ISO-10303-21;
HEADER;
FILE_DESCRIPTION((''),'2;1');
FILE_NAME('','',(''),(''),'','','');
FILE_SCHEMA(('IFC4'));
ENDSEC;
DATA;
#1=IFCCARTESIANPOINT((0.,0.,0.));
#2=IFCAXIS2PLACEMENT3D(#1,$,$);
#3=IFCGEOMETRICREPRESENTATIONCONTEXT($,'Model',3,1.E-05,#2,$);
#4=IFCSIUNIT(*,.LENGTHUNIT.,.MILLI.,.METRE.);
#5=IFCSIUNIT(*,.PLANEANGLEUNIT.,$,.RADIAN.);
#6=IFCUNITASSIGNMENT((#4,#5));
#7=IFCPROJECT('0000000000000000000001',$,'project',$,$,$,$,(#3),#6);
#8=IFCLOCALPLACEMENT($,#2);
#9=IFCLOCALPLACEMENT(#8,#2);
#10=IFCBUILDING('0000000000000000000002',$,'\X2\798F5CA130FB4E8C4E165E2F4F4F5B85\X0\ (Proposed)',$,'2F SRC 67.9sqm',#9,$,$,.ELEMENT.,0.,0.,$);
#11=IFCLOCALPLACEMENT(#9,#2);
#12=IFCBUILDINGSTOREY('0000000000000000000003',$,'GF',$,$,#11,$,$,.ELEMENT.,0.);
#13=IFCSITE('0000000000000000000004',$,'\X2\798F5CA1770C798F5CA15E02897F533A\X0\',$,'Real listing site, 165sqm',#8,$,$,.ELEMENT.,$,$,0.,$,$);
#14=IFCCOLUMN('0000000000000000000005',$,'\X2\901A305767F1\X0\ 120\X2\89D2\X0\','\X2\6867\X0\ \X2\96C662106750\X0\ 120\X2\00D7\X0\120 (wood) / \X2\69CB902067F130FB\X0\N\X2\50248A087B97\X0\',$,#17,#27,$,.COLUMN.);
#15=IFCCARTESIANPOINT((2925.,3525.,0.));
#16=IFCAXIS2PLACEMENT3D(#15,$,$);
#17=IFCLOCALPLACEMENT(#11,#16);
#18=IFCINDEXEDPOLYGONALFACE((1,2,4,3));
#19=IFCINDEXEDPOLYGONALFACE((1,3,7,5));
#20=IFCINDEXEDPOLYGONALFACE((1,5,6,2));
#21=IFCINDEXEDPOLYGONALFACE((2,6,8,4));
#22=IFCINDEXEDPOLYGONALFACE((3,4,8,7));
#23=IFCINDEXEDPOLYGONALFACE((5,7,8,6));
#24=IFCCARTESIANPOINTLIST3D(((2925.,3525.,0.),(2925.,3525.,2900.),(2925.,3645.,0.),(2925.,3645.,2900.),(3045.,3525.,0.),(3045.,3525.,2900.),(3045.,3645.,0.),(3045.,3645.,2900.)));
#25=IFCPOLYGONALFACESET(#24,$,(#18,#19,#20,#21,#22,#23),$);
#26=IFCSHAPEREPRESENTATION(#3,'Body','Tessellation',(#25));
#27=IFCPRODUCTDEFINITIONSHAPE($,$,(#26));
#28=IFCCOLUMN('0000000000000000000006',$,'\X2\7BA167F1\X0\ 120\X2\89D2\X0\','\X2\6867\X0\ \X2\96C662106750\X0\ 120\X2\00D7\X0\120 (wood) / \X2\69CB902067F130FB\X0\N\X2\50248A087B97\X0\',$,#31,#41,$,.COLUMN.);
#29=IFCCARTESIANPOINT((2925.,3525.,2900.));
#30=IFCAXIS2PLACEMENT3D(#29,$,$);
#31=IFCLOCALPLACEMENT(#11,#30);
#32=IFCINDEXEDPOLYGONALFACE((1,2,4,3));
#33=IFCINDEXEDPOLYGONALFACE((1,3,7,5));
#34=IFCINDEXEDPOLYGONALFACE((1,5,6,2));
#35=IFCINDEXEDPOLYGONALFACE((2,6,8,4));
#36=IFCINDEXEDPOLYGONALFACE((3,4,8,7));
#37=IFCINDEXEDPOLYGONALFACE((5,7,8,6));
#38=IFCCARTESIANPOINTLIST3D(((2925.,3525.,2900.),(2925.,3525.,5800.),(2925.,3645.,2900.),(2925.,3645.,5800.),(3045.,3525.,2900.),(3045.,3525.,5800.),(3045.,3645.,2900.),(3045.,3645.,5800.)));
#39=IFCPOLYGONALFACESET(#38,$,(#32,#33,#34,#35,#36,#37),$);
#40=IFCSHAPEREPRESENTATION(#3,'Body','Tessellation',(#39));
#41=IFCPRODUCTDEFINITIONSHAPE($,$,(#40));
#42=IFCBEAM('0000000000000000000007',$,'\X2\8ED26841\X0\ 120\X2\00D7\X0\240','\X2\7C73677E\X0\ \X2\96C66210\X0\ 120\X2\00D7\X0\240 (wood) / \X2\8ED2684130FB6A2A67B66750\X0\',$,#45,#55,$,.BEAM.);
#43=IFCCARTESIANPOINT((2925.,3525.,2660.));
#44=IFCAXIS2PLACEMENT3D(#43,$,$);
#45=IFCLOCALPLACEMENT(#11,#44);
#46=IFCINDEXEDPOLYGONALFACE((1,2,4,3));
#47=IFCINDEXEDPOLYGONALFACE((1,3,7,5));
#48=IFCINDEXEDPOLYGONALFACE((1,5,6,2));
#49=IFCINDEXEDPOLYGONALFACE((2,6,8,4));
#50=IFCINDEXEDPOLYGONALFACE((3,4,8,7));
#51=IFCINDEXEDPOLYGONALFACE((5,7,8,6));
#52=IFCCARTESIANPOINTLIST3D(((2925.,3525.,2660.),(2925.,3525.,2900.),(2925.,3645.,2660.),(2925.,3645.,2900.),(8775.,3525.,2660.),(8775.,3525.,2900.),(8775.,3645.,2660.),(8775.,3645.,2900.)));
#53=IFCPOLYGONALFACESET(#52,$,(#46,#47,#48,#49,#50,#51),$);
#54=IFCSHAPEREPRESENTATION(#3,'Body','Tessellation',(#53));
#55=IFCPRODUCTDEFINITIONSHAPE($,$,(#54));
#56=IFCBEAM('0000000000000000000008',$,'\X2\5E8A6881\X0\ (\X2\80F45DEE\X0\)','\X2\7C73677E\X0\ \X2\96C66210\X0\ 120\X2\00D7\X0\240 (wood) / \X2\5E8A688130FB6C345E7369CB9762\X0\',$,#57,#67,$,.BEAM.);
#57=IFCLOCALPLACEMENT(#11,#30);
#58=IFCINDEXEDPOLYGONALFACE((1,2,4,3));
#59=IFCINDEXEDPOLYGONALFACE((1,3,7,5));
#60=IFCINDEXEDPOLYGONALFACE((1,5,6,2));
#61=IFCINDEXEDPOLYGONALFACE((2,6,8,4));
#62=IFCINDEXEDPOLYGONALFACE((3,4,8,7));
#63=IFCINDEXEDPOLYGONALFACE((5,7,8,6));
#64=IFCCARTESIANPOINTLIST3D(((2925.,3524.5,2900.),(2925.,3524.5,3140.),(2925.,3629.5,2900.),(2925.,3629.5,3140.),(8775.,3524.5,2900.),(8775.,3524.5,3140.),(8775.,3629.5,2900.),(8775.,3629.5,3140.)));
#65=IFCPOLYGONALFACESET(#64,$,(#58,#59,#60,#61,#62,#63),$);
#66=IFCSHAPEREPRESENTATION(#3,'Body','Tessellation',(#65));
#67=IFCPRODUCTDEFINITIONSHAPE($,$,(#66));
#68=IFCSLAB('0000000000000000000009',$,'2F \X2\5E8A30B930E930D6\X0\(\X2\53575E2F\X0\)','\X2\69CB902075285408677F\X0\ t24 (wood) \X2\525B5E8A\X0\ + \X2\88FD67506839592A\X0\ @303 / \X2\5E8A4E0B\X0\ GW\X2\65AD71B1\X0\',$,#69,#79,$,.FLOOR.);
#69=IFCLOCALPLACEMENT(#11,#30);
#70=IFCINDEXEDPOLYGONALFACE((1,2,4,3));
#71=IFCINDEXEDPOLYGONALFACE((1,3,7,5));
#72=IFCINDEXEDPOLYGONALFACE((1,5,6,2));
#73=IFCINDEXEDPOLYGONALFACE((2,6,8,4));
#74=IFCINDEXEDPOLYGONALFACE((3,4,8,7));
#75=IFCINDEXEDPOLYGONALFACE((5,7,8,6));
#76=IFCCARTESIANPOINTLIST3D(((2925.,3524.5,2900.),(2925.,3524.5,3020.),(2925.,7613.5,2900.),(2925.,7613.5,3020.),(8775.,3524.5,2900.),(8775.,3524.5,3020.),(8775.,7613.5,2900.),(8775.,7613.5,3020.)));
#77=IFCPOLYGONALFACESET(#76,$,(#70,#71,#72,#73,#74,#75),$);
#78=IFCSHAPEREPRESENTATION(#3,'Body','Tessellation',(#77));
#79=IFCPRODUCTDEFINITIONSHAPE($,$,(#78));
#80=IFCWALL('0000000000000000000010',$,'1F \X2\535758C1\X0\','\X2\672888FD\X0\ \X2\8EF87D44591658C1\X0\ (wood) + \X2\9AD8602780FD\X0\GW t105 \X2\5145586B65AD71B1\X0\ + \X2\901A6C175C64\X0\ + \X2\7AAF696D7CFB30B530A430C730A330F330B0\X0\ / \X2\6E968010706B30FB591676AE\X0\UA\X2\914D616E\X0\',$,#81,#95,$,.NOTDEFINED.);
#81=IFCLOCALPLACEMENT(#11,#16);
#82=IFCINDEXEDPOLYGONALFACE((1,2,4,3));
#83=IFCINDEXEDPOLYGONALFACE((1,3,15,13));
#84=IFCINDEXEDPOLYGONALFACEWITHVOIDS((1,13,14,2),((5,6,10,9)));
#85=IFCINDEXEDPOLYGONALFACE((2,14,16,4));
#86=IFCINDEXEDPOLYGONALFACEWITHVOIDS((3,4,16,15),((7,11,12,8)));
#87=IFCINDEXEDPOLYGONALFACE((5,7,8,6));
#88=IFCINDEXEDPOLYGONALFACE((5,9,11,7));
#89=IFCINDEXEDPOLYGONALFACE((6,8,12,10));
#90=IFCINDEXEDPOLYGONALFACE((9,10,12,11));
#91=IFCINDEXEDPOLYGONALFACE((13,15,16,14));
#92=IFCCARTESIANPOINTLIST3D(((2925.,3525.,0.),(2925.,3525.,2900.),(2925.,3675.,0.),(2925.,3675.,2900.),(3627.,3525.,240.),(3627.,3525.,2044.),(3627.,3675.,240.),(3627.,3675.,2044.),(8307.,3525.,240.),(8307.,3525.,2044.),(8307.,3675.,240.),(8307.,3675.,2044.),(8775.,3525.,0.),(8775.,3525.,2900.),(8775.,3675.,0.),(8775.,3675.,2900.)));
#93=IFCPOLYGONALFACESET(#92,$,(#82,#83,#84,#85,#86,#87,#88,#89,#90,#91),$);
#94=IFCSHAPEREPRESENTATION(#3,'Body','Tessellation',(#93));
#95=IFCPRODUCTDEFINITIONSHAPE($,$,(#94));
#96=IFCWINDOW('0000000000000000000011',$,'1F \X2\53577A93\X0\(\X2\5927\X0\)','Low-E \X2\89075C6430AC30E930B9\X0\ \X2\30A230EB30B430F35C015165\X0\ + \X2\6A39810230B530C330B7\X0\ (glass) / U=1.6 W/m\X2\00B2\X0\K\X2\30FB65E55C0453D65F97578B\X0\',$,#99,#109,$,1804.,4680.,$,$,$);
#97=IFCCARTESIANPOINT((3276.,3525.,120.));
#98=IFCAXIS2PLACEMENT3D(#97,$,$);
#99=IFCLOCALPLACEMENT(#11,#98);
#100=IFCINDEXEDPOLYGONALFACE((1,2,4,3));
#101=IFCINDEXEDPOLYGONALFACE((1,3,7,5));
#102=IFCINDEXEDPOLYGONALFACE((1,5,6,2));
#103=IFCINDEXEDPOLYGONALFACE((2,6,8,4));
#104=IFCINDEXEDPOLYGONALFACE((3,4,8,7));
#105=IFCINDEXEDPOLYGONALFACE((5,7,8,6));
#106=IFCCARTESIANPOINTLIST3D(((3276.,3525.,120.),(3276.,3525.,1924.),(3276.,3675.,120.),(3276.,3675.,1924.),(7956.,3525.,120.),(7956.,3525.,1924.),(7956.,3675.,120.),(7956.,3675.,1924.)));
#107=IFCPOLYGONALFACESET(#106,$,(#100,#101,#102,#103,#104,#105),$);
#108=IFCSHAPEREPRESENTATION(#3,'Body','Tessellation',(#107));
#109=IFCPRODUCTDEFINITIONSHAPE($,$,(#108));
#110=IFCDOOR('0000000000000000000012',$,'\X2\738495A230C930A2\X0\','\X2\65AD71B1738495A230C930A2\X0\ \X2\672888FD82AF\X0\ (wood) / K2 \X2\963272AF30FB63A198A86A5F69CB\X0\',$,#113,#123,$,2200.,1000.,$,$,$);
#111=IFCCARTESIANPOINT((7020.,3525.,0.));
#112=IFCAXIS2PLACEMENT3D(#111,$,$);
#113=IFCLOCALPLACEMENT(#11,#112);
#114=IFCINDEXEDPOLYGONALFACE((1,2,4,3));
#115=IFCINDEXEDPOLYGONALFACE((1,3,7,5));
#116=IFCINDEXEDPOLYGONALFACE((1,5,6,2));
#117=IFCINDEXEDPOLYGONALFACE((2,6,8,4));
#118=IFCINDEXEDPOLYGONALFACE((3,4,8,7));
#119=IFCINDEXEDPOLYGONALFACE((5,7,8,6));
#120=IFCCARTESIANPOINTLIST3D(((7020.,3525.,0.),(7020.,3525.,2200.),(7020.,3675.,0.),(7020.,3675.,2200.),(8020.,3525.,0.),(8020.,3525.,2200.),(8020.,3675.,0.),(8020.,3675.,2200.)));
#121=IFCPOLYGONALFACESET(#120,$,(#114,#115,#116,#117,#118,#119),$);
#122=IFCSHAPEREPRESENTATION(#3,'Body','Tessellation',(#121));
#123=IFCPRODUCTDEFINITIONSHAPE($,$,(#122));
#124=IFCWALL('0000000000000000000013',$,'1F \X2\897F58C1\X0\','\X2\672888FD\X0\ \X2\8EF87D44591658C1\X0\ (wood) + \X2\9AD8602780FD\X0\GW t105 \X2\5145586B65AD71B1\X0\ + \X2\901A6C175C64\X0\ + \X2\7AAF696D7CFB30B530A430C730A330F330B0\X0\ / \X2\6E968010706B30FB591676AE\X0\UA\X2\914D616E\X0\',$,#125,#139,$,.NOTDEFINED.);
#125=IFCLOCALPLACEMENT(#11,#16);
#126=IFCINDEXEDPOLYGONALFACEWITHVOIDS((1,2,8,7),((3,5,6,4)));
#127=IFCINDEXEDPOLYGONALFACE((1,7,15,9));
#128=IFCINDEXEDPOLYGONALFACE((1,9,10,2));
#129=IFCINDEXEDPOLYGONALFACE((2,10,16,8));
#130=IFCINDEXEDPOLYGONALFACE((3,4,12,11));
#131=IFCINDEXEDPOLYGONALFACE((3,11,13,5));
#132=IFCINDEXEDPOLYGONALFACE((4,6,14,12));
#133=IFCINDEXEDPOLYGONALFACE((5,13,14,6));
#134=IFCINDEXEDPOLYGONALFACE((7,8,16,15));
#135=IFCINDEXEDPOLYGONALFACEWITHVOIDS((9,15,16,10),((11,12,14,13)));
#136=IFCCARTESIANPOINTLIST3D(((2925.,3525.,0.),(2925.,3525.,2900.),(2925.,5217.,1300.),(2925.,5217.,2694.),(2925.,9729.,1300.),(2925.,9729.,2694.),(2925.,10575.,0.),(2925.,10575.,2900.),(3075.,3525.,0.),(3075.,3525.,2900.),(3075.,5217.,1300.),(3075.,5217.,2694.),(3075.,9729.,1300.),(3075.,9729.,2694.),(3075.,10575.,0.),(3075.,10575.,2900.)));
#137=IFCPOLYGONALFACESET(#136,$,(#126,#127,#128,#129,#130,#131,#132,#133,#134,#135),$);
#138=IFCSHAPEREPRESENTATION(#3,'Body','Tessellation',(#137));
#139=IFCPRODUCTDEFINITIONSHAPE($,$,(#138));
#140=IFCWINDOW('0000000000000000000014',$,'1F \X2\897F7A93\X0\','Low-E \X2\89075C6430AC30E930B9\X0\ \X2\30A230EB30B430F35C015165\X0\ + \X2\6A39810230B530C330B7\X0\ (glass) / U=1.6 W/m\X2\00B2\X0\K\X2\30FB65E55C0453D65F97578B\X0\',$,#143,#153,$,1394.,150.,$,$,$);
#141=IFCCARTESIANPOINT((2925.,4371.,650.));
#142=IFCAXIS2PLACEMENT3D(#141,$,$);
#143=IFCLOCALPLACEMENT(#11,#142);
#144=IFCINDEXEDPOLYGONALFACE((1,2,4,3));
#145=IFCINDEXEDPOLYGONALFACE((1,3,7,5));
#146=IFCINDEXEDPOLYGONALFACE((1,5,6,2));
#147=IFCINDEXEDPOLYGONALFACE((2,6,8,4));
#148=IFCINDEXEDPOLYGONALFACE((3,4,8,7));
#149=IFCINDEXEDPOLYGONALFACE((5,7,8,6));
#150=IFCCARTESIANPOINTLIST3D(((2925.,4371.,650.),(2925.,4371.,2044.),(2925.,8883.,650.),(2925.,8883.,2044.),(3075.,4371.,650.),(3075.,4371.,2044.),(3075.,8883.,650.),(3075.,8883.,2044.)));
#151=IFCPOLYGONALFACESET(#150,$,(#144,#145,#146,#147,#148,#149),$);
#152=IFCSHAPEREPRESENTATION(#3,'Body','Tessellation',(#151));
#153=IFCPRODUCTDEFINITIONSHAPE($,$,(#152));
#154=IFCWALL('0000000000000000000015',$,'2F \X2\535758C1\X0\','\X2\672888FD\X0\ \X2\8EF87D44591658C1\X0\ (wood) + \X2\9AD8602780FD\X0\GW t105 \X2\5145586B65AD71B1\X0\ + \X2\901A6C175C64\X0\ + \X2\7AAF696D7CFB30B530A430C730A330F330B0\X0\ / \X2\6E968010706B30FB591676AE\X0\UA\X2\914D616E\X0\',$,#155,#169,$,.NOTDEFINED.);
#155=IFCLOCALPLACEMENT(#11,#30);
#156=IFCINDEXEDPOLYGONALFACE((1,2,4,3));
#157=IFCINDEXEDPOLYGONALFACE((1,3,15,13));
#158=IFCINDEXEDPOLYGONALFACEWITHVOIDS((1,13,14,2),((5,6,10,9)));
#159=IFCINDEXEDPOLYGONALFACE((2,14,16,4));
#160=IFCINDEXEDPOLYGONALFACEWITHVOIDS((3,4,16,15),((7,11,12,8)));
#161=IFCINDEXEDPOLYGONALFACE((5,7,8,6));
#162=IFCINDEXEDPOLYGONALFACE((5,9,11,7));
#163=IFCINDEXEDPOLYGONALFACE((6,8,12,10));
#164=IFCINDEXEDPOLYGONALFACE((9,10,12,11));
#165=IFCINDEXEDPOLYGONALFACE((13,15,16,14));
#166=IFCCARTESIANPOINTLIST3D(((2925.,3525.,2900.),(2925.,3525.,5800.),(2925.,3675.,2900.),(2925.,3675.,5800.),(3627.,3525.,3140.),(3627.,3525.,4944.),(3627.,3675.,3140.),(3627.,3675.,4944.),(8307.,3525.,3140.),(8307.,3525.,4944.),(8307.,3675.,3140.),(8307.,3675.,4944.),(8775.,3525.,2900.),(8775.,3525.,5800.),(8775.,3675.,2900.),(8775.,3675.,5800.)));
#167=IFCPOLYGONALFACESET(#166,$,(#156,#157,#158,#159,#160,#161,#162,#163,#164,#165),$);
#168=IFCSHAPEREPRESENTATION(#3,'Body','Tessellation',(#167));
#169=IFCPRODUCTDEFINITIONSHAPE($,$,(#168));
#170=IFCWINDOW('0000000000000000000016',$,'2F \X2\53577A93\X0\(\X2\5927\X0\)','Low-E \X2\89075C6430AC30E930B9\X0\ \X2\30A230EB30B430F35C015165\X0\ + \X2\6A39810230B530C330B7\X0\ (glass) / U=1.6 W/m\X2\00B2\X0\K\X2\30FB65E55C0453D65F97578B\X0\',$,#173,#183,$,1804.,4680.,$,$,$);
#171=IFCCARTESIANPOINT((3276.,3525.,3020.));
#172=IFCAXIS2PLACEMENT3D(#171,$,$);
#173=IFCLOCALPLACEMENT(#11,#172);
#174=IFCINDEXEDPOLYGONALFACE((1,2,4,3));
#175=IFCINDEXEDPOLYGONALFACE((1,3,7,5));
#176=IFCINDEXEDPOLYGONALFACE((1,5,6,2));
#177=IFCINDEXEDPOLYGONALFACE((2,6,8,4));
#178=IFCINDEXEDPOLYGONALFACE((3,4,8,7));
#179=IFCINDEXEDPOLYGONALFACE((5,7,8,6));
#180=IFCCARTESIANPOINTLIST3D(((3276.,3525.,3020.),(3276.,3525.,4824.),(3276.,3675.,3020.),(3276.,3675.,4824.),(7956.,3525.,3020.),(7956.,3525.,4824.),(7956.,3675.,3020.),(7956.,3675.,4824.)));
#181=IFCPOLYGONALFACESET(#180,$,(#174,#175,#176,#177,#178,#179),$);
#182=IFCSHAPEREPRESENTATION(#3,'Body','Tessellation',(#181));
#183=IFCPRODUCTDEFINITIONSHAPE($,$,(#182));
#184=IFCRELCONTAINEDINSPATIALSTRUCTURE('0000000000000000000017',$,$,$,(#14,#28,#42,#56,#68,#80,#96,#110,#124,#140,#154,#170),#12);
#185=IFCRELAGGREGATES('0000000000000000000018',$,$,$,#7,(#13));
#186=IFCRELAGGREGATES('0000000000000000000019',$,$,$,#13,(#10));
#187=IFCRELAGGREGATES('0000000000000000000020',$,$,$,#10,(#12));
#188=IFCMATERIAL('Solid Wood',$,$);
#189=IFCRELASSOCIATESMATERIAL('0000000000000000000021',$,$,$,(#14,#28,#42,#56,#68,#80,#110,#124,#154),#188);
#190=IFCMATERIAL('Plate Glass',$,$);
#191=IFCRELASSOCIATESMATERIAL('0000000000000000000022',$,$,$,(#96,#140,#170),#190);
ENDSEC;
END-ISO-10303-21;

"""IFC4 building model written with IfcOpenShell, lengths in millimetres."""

from ifc_helpers import new_model, si_unit, frame, frame_2d, origin, place, context, project, spatial, rectangle, extrude, material, element, fill, save


model = new_model("IFC4")

# Units and contexts
model_context = context("Model", 3, precision=1e-05, world=origin())
ifc_project = project(units=[si_unit("LENGTHUNIT", "METRE", prefix="MILLI"), si_unit("PLANEANGLEUNIT", "RADIAN")], contexts=[model_context])

# Site, building, storey
site_placement = place(None, origin())
site = spatial("IfcSite", under=ifc_project, at=site_placement, Name="福岡県福岡市西区", ObjectType="Real listing site, 165sqm", CompositionType="ELEMENT", RefElevation=0.0)
building_placement = place(site_placement, origin())
building = spatial("IfcBuilding", under=site, at=building_placement, Name="福岡・二世帯住宅 (Proposed)", ObjectType="2F SRC 67.9sqm", CompositionType="ELEMENT", ElevationOfRefHeight=0.0, ElevationOfTerrain=0.0)
storey_placement = place(building_placement, origin())
storey = spatial("IfcBuildingStorey", under=building, at=storey_placement, Name="GF", CompositionType="ELEMENT", Elevation=0.0)

# Columns
ifc_material_1 = material(Name="Solid Wood")
column_1_placement = place(storey_placement, frame((2925.0, 3525.0, 0.0)))
element("IfcColumn", 1, at=column_1_placement, inside=storey, material=ifc_material_1, Name="通し柱 120角", Description="桧 集成材 120×120 (wood) / 構造柱・N値計算", PredefinedType="COLUMN", context=model_context, shape_type="SweptSolid", body=[
    extrude(rectangle(XDim=120.0, YDim=120.0, at=frame_2d((60.0, 60.0))), frame((2925.0, 3525.0, 0.0)), (0.0, 0.0, 1.0), 2900.0),
])
column_2_placement = place(storey_placement, frame((2925.0, 3525.0, 2900.0)))
element("IfcColumn", 2, at=column_2_placement, inside=storey, material=ifc_material_1, Name="管柱 120角", Description="桧 集成材 120×120 (wood) / 構造柱・N値計算", PredefinedType="COLUMN", context=model_context, shape_type="SweptSolid", body=[
    extrude(rectangle(XDim=120.0, YDim=120.0, at=frame_2d((60.0, 60.0))), frame((2925.0, 3525.0, 2900.0)), (0.0, 0.0, 1.0), 2900.0),
])

# Beams
beam_1_placement = place(storey_placement, frame((2925.0, 3525.0, 2660.0)))
element("IfcBeam", 3, at=beam_1_placement, inside=storey, material=ifc_material_1, Name="軒桁 120×240", Description="米松 集成 120×240 (wood) / 軒桁・横架材", PredefinedType="BEAM", context=model_context, shape_type="SweptSolid", body=[
    extrude(rectangle(XDim=5850.0, YDim=120.0, at=frame_2d((2925.0, 60.0))), frame((2925.0, 3525.0, 2660.0)), (0.0, 0.0, 1.0), 240.0),
])
beam_2_placement = place(storey_placement, frame((2925.0, 3525.0, 2900.0)))
element("IfcBeam", 4, at=beam_2_placement, inside=storey, material=ifc_material_1, Name="床梁 (胴差)", Description="米松 集成 120×240 (wood) / 床梁・水平構面", PredefinedType="BEAM", context=model_context, shape_type="SweptSolid", body=[
    extrude(rectangle(XDim=5850.0, YDim=105.0, at=frame_2d((2925.0, 52.0))), frame((2925.0, 3525.0, 2900.0)), (0.0, 0.0, 1.0), 240.0),
])

# Slab
slab_1_placement = place(storey_placement, frame((2925.0, 3525.0, 2900.0)))
element("IfcSlab", 5, at=slab_1_placement, inside=storey, material=ifc_material_1, Name="2F 床スラブ(南帯)", Description="構造用合板 t24 (wood) 剛床 + 製材根太 @303 / 床下 GW断熱", PredefinedType="FLOOR", context=model_context, shape_type="SweptSolid", body=[
    extrude(rectangle(XDim=5850.0, YDim=4089.0, at=frame_2d((2925.0, 2044.0))), frame((2925.0, 3525.0, 2900.0)), (0.0, 0.0, 1.0), 120.0),
])

# Wall, openings, window, door
wall_1_placement = place(storey_placement, frame((2925.0, 3525.0, 0.0)))
wall_1 = element("IfcWall", 6, at=wall_1_placement, inside=storey, material=ifc_material_1, Name="1F 南壁", Description="木製 軸組外壁 (wood) + 高性能GW t105 充填断熱 + 通気層 + 窯業系サイディング / 準耐火・外皮UA配慮", PredefinedType="NOTDEFINED", context=model_context, shape_type="SweptSolid", body=[
    extrude(rectangle(XDim=5850.0, YDim=150.0, at=frame_2d((2925.0, 75.0))), frame((2925.0, 3525.0, 0.0)), (0.0, 0.0, 1.0), 2900.0),
])
opening_1_placement = place(storey_placement, frame((3276.0, 3525.0, 120.0)))
opening_1 = element("IfcOpeningElement", 7, at=opening_1_placement, cuts=wall_1, PredefinedType="NOTDEFINED", context=model_context, shape_type="SweptSolid", body=[
    extrude(rectangle(XDim=4680.0, YDim=150.0, at=frame_2d((2340.0, 75.0))), frame((3276.0, 3525.0, 120.0)), (0.0, 0.0, 1.0), 1804.0),
])
opening_2_placement = place(storey_placement, frame((7020.0, 3525.0, 0.0)))
opening_2 = element("IfcOpeningElement", 8, at=opening_2_placement, cuts=wall_1, PredefinedType="NOTDEFINED", context=model_context, shape_type="SweptSolid", body=[
    extrude(rectangle(XDim=1000.0, YDim=150.0, at=frame_2d((500.0, 75.0))), frame((7020.0, 3525.0, 0.0)), (0.0, 0.0, 1.0), 2200.0),
])
ifc_material_2 = material(Name="Plate Glass")
window_1_placement = place(storey_placement, frame((3276.0, 3525.0, 120.0)))
window_1 = element("IfcWindow", 9, at=window_1_placement, inside=storey, material=ifc_material_2, Name="1F 南窓(大)", Description="Low-E 複層ガラス アルゴン封入 + 樹脂サッシ (glass) / U=1.6 W/m²K・日射取得型", OverallHeight=1804.0, OverallWidth=4680.0, context=model_context, shape_type="SweptSolid", body=[
    extrude(rectangle(XDim=4680.0, YDim=150.0, at=frame_2d((2340.0, 75.0))), frame((3276.0, 3525.0, 120.0)), (0.0, 0.0, 1.0), 1804.0),
])
fill(opening_1, window_1)
door_placement = place(storey_placement, frame((7020.0, 3525.0, 0.0)))
door = element("IfcDoor", 10, at=door_placement, inside=storey, material=ifc_material_1, Name="玄関ドア", Description="断熱玄関ドア 木製芯 (wood) / K2 防犯・採風機構", OverallHeight=2200.0, OverallWidth=1000.0, context=model_context, shape_type="SweptSolid", body=[
    extrude(rectangle(XDim=1000.0, YDim=150.0, at=frame_2d((500.0, 75.0))), frame((7020.0, 3525.0, 0.0)), (0.0, 0.0, 1.0), 2200.0),
])
fill(opening_2, door)

# Walls, openings, windows
wall_2_placement = place(storey_placement, frame((2925.0, 3525.0, 0.0)))
wall_2 = element("IfcWall", 11, at=wall_2_placement, inside=storey, material=ifc_material_1, Name="1F 西壁", Description="木製 軸組外壁 (wood) + 高性能GW t105 充填断熱 + 通気層 + 窯業系サイディング / 準耐火・外皮UA配慮", PredefinedType="NOTDEFINED", context=model_context, shape_type="SweptSolid", body=[
    extrude(rectangle(XDim=150.0, YDim=7050.0, at=frame_2d((75.0, 3525.0))), frame((2925.0, 3525.0, 0.0)), (0.0, 0.0, 1.0), 2900.0),
])
opening_3_placement = place(storey_placement, frame((2925.0, 4371.0, 650.0)))
opening_3 = element("IfcOpeningElement", 12, at=opening_3_placement, cuts=wall_2, PredefinedType="NOTDEFINED", context=model_context, shape_type="SweptSolid", body=[
    extrude(rectangle(XDim=150.0, YDim=4512.0, at=frame_2d((75.0, 2256.0))), frame((2925.0, 4371.0, 650.0)), (0.0, 0.0, 1.0), 1394.0),
])
window_2_placement = place(storey_placement, frame((2925.0, 4371.0, 650.0)))
window_2 = element("IfcWindow", 13, at=window_2_placement, inside=storey, material=ifc_material_2, Name="1F 西窓", Description="Low-E 複層ガラス アルゴン封入 + 樹脂サッシ (glass) / U=1.6 W/m²K・日射取得型", OverallHeight=1394.0, OverallWidth=150.0, context=model_context, shape_type="SweptSolid", body=[
    extrude(rectangle(XDim=150.0, YDim=4512.0, at=frame_2d((75.0, 2256.0))), frame((2925.0, 4371.0, 650.0)), (0.0, 0.0, 1.0), 1394.0),
])
fill(opening_3, window_2)
wall_3_placement = place(storey_placement, frame((2925.0, 3525.0, 2900.0)))
wall_3 = element("IfcWall", 14, at=wall_3_placement, inside=storey, material=ifc_material_1, Name="2F 南壁", Description="木製 軸組外壁 (wood) + 高性能GW t105 充填断熱 + 通気層 + 窯業系サイディング / 準耐火・外皮UA配慮", PredefinedType="NOTDEFINED", context=model_context, shape_type="SweptSolid", body=[
    extrude(rectangle(XDim=5850.0, YDim=150.0, at=frame_2d((2925.0, 75.0))), frame((2925.0, 3525.0, 2900.0)), (0.0, 0.0, 1.0), 2900.0),
])
opening_4_placement = place(storey_placement, frame((3276.0, 3525.0, 3020.0)))
opening_4 = element("IfcOpeningElement", 15, at=opening_4_placement, cuts=wall_3, PredefinedType="NOTDEFINED", context=model_context, shape_type="SweptSolid", body=[
    extrude(rectangle(XDim=4680.0, YDim=150.0, at=frame_2d((2340.0, 75.0))), frame((3276.0, 3525.0, 3020.0)), (0.0, 0.0, 1.0), 1804.0),
])
window_3_placement = place(storey_placement, frame((3276.0, 3525.0, 3020.0)))
window_3 = element("IfcWindow", 16, at=window_3_placement, inside=storey, material=ifc_material_2, Name="2F 南窓(大)", Description="Low-E 複層ガラス アルゴン封入 + 樹脂サッシ (glass) / U=1.6 W/m²K・日射取得型", OverallHeight=1804.0, OverallWidth=4680.0, context=model_context, shape_type="SweptSolid", body=[
    extrude(rectangle(XDim=4680.0, YDim=150.0, at=frame_2d((2340.0, 75.0))), frame((3276.0, 3525.0, 3020.0)), (0.0, 0.0, 1.0), 1804.0),
])
fill(opening_4, window_3)

save(model, "model.ifc")
